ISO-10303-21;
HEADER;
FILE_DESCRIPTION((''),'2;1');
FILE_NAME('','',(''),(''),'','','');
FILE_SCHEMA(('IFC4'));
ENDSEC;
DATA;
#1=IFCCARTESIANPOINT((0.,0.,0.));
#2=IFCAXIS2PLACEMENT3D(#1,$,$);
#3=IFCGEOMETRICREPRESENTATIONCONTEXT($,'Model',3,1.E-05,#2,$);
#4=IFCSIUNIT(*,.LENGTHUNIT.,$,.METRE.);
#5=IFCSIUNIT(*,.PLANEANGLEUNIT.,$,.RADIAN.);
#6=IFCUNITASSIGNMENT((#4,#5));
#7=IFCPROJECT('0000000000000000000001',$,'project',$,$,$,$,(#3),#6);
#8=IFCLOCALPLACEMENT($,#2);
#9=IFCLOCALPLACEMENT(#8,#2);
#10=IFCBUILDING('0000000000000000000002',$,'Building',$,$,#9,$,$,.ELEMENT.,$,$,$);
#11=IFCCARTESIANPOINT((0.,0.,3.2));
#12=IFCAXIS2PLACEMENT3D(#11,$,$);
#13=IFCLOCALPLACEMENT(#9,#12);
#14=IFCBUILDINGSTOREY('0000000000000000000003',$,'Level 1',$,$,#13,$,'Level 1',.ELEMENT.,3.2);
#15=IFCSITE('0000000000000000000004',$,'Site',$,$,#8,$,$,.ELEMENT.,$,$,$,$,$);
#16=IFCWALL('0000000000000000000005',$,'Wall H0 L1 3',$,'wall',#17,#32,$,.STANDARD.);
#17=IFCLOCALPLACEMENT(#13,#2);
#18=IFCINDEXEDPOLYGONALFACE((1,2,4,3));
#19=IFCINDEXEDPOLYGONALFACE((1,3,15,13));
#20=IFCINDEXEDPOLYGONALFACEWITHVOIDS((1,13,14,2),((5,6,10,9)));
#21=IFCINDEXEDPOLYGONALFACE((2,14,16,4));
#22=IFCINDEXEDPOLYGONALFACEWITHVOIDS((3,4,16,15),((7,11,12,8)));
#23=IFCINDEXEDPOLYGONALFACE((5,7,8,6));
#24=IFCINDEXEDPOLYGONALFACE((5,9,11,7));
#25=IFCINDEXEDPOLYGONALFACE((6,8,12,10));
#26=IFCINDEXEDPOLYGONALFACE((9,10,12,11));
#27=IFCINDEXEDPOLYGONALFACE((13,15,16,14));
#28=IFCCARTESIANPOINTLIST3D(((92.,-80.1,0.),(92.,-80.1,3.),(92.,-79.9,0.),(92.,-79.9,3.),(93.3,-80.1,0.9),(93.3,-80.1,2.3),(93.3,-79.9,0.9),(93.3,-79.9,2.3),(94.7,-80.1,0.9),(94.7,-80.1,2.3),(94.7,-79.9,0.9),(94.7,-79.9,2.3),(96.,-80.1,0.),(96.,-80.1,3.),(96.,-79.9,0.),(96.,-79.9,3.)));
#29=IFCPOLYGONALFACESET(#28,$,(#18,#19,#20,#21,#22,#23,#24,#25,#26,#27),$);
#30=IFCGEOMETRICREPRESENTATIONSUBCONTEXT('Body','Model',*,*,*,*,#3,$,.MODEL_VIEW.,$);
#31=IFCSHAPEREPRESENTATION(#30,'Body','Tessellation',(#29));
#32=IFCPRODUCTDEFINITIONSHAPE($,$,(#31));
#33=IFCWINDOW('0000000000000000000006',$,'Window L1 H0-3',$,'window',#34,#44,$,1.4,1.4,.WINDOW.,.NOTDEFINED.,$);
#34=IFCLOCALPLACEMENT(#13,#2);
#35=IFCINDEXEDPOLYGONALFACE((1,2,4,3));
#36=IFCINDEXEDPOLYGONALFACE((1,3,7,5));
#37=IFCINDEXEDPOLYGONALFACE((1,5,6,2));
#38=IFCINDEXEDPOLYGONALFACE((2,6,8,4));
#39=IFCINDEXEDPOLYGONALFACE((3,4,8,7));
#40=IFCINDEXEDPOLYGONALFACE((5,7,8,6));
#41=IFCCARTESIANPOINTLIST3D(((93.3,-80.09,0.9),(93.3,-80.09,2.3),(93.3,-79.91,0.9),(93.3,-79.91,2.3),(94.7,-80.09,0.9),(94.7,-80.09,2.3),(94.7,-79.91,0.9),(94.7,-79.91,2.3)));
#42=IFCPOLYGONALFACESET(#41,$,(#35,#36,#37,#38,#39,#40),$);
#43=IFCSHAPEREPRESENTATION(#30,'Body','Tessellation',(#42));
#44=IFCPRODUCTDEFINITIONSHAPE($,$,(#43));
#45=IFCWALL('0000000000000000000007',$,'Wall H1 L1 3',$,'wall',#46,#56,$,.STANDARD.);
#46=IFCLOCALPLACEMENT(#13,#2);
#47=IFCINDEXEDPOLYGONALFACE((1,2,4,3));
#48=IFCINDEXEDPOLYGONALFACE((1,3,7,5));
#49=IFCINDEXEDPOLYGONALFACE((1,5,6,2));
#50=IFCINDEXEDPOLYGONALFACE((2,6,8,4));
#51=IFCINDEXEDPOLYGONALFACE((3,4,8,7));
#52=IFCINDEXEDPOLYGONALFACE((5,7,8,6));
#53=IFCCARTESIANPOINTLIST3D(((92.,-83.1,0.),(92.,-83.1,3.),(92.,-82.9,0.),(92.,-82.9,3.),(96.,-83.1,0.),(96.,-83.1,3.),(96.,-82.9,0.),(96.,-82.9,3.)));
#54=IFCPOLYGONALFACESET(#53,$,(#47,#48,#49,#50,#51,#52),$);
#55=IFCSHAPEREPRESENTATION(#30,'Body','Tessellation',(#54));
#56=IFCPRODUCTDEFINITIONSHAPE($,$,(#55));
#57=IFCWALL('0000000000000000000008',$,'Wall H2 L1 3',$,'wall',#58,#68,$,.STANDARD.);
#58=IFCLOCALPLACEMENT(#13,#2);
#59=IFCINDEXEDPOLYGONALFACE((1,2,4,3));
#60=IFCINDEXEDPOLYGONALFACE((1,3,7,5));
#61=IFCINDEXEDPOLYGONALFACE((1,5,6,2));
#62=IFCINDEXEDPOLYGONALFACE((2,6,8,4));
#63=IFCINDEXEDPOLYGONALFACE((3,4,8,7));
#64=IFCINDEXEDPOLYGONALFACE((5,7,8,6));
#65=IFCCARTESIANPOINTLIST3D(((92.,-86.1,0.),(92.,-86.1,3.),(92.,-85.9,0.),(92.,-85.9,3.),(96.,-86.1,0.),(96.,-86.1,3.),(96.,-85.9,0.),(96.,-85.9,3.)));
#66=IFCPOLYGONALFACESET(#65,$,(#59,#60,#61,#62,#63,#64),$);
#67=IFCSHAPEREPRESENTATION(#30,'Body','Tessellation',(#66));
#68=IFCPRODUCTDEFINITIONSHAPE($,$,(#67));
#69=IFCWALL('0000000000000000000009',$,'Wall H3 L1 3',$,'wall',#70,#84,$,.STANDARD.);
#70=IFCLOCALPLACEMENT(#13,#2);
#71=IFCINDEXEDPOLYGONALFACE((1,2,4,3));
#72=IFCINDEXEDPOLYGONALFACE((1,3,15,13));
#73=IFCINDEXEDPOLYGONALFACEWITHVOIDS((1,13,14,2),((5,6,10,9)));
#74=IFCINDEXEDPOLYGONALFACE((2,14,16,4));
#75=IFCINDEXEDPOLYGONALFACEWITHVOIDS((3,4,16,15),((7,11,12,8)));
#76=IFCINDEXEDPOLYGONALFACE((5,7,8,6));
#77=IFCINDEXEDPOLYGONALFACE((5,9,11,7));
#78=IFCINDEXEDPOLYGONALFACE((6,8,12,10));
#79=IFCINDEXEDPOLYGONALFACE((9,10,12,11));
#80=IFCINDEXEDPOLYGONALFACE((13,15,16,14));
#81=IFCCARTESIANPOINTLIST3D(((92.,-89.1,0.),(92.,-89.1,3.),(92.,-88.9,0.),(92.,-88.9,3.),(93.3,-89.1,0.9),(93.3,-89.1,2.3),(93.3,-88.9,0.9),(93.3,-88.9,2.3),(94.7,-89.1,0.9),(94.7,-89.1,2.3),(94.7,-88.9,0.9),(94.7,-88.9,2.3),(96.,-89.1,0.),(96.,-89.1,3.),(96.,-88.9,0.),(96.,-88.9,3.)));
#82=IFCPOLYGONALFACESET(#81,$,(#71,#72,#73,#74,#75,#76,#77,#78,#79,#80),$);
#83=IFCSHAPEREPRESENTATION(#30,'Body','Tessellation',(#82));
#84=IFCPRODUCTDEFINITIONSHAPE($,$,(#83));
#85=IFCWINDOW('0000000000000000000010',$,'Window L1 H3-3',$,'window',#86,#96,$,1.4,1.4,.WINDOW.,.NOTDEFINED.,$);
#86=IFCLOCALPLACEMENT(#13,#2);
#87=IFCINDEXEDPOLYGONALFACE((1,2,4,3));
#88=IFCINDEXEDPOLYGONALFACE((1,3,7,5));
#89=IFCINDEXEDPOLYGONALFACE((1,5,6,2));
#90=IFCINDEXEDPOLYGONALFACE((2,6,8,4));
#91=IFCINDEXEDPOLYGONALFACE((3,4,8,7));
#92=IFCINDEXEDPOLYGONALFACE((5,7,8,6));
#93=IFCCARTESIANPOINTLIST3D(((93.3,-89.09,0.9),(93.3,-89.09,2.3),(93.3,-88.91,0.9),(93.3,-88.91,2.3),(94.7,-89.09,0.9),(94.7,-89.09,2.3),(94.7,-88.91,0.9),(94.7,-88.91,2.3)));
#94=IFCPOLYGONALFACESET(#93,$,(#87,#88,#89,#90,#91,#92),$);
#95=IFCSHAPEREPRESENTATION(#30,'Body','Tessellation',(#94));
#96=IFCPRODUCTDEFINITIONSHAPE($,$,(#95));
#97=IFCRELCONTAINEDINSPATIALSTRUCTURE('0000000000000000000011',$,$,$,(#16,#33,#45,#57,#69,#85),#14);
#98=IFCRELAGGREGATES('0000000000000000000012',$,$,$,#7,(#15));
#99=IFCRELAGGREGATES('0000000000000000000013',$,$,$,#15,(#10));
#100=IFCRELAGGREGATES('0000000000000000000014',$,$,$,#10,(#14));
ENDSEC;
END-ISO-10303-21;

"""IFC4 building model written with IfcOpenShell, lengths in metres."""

from ifc_helpers import new_model, si_unit, frame, frame_2d, origin, origin_2d, place, context, subcontext, project, spatial, rectangle, extrude, element, fill, save


model = new_model("IFC4")

# Units and contexts
model_context = context("Model", 3, precision=1e-05, world=origin())
body_context = subcontext(model_context, "Body", "Model", "MODEL_VIEW")
ifc_project = project(units=[si_unit("LENGTHUNIT", "METRE"), si_unit("PLANEANGLEUNIT", "RADIAN")], contexts=[model_context])

# Site, building, storey
site_placement = place(None, origin())
site = spatial("IfcSite", under=ifc_project, at=site_placement, Name="Site", CompositionType="ELEMENT")
building_placement = place(site_placement, origin())
building = spatial("IfcBuilding", under=site, at=building_placement, Name="Building", CompositionType="ELEMENT")
storey_placement = place(building_placement, frame((0.0, 0.0, 3.2)))
storey = spatial("IfcBuildingStorey", under=building, at=storey_placement, Name="Level 1", LongName="Level 1", CompositionType="ELEMENT", Elevation=3.2)

# Wall, opening, window
wall_1_placement = place(storey_placement, frame((92.0, -80.0, 0.0), z_axis=(0.0, 0.0, 1.0), x_axis=(1.0, 0.0, 0.0)))
wall_1 = element("IfcWall", 1, at=wall_1_placement, inside=storey, Name="Wall H0 L1 3", ObjectType="wall", PredefinedType="STANDARD", context=body_context, shape_type="SweptSolid", body=[
    extrude(rectangle(XDim=4.0, YDim=0.2, at=frame_2d((2.0, 0.0))), origin(), (0.0, 0.0, 1.0), 3.0),
])
opening_1_placement = place(storey_placement, frame((94.0, -80.0, 0.9), z_axis=(0.0, 0.0, 1.0), x_axis=(1.0, 0.0, 0.0)))
opening_1 = element("IfcOpeningElement", 2, at=opening_1_placement, cuts=wall_1, ObjectType="Opening", PredefinedType="OPENING", context=body_context, shape_type="SweptSolid", body=[
    extrude(rectangle(XDim=1.4, YDim=0.22, at=origin_2d()), origin(), (0.0, 0.0, 1.0), 1.4),
])
window_1_placement = place(storey_placement, frame((94.0, -80.0, 0.9), z_axis=(0.0, 0.0, 1.0), x_axis=(1.0, 0.0, 0.0)))
window_1 = element("IfcWindow", 3, at=window_1_placement, inside=storey, Name="Window L1 H0-3", ObjectType="window", OverallHeight=1.4, OverallWidth=1.4, PartitioningType="NOTDEFINED", PredefinedType="WINDOW", context=body_context, shape_type="SweptSolid", body=[
    extrude(rectangle(XDim=1.4, YDim=0.18, at=origin_2d()), origin(), (0.0, 0.0, 1.0), 1.4),
])
fill(opening_1, window_1)

# Walls
for number, where, z_axis, x_axis, name in (
    (4, (92.0, -83.0, 0.0), (0.0, 0.0, 1.0), (1.0, 0.0, 0.0), "Wall H1 L1 3"),
    (5, (92.0, -86.0, 0.0), (0.0, 0.0, 1.0), (1.0, 0.0, 0.0), "Wall H2 L1 3"),
):
    element("IfcWall", number, at=place(storey_placement, frame(where, z_axis=z_axis, x_axis=x_axis)), inside=storey, Name=name, ObjectType="wall", PredefinedType="STANDARD", context=body_context, shape_type="SweptSolid", body=[
        extrude(rectangle(XDim=4.0, YDim=0.2, at=frame_2d((2.0, 0.0))), origin(), (0.0, 0.0, 1.0), 3.0),
    ])

# Wall, opening, window
wall_2_placement = place(storey_placement, frame((92.0, -89.0, 0.0), z_axis=(0.0, 0.0, 1.0), x_axis=(1.0, 0.0, 0.0)))
wall_2 = element("IfcWall", 6, at=wall_2_placement, inside=storey, Name="Wall H3 L1 3", ObjectType="wall", PredefinedType="STANDARD", context=body_context, shape_type="SweptSolid", body=[
    extrude(rectangle(XDim=4.0, YDim=0.2, at=frame_2d((2.0, 0.0))), origin(), (0.0, 0.0, 1.0), 3.0),
])
opening_2_placement = place(storey_placement, frame((94.0, -89.0, 0.9), z_axis=(0.0, 0.0, 1.0), x_axis=(1.0, 0.0, 0.0)))
opening_2 = element("IfcOpeningElement", 7, at=opening_2_placement, cuts=wall_2, ObjectType="Opening", PredefinedType="OPENING", context=body_context, shape_type="SweptSolid", body=[
    extrude(rectangle(XDim=1.4, YDim=0.22, at=origin_2d()), origin(), (0.0, 0.0, 1.0), 1.4),
])
window_2_placement = place(storey_placement, frame((94.0, -89.0, 0.9), z_axis=(0.0, 0.0, 1.0), x_axis=(1.0, 0.0, 0.0)))
window_2 = element("IfcWindow", 8, at=window_2_placement, inside=storey, Name="Window L1 H3-3", ObjectType="window", OverallHeight=1.4, OverallWidth=1.4, PartitioningType="NOTDEFINED", PredefinedType="WINDOW", context=body_context, shape_type="SweptSolid", body=[
    extrude(rectangle(XDim=1.4, YDim=0.18, at=origin_2d()), origin(), (0.0, 0.0, 1.0), 1.4),
])
fill(opening_2, window_2)

save(model, "model.ifc")
